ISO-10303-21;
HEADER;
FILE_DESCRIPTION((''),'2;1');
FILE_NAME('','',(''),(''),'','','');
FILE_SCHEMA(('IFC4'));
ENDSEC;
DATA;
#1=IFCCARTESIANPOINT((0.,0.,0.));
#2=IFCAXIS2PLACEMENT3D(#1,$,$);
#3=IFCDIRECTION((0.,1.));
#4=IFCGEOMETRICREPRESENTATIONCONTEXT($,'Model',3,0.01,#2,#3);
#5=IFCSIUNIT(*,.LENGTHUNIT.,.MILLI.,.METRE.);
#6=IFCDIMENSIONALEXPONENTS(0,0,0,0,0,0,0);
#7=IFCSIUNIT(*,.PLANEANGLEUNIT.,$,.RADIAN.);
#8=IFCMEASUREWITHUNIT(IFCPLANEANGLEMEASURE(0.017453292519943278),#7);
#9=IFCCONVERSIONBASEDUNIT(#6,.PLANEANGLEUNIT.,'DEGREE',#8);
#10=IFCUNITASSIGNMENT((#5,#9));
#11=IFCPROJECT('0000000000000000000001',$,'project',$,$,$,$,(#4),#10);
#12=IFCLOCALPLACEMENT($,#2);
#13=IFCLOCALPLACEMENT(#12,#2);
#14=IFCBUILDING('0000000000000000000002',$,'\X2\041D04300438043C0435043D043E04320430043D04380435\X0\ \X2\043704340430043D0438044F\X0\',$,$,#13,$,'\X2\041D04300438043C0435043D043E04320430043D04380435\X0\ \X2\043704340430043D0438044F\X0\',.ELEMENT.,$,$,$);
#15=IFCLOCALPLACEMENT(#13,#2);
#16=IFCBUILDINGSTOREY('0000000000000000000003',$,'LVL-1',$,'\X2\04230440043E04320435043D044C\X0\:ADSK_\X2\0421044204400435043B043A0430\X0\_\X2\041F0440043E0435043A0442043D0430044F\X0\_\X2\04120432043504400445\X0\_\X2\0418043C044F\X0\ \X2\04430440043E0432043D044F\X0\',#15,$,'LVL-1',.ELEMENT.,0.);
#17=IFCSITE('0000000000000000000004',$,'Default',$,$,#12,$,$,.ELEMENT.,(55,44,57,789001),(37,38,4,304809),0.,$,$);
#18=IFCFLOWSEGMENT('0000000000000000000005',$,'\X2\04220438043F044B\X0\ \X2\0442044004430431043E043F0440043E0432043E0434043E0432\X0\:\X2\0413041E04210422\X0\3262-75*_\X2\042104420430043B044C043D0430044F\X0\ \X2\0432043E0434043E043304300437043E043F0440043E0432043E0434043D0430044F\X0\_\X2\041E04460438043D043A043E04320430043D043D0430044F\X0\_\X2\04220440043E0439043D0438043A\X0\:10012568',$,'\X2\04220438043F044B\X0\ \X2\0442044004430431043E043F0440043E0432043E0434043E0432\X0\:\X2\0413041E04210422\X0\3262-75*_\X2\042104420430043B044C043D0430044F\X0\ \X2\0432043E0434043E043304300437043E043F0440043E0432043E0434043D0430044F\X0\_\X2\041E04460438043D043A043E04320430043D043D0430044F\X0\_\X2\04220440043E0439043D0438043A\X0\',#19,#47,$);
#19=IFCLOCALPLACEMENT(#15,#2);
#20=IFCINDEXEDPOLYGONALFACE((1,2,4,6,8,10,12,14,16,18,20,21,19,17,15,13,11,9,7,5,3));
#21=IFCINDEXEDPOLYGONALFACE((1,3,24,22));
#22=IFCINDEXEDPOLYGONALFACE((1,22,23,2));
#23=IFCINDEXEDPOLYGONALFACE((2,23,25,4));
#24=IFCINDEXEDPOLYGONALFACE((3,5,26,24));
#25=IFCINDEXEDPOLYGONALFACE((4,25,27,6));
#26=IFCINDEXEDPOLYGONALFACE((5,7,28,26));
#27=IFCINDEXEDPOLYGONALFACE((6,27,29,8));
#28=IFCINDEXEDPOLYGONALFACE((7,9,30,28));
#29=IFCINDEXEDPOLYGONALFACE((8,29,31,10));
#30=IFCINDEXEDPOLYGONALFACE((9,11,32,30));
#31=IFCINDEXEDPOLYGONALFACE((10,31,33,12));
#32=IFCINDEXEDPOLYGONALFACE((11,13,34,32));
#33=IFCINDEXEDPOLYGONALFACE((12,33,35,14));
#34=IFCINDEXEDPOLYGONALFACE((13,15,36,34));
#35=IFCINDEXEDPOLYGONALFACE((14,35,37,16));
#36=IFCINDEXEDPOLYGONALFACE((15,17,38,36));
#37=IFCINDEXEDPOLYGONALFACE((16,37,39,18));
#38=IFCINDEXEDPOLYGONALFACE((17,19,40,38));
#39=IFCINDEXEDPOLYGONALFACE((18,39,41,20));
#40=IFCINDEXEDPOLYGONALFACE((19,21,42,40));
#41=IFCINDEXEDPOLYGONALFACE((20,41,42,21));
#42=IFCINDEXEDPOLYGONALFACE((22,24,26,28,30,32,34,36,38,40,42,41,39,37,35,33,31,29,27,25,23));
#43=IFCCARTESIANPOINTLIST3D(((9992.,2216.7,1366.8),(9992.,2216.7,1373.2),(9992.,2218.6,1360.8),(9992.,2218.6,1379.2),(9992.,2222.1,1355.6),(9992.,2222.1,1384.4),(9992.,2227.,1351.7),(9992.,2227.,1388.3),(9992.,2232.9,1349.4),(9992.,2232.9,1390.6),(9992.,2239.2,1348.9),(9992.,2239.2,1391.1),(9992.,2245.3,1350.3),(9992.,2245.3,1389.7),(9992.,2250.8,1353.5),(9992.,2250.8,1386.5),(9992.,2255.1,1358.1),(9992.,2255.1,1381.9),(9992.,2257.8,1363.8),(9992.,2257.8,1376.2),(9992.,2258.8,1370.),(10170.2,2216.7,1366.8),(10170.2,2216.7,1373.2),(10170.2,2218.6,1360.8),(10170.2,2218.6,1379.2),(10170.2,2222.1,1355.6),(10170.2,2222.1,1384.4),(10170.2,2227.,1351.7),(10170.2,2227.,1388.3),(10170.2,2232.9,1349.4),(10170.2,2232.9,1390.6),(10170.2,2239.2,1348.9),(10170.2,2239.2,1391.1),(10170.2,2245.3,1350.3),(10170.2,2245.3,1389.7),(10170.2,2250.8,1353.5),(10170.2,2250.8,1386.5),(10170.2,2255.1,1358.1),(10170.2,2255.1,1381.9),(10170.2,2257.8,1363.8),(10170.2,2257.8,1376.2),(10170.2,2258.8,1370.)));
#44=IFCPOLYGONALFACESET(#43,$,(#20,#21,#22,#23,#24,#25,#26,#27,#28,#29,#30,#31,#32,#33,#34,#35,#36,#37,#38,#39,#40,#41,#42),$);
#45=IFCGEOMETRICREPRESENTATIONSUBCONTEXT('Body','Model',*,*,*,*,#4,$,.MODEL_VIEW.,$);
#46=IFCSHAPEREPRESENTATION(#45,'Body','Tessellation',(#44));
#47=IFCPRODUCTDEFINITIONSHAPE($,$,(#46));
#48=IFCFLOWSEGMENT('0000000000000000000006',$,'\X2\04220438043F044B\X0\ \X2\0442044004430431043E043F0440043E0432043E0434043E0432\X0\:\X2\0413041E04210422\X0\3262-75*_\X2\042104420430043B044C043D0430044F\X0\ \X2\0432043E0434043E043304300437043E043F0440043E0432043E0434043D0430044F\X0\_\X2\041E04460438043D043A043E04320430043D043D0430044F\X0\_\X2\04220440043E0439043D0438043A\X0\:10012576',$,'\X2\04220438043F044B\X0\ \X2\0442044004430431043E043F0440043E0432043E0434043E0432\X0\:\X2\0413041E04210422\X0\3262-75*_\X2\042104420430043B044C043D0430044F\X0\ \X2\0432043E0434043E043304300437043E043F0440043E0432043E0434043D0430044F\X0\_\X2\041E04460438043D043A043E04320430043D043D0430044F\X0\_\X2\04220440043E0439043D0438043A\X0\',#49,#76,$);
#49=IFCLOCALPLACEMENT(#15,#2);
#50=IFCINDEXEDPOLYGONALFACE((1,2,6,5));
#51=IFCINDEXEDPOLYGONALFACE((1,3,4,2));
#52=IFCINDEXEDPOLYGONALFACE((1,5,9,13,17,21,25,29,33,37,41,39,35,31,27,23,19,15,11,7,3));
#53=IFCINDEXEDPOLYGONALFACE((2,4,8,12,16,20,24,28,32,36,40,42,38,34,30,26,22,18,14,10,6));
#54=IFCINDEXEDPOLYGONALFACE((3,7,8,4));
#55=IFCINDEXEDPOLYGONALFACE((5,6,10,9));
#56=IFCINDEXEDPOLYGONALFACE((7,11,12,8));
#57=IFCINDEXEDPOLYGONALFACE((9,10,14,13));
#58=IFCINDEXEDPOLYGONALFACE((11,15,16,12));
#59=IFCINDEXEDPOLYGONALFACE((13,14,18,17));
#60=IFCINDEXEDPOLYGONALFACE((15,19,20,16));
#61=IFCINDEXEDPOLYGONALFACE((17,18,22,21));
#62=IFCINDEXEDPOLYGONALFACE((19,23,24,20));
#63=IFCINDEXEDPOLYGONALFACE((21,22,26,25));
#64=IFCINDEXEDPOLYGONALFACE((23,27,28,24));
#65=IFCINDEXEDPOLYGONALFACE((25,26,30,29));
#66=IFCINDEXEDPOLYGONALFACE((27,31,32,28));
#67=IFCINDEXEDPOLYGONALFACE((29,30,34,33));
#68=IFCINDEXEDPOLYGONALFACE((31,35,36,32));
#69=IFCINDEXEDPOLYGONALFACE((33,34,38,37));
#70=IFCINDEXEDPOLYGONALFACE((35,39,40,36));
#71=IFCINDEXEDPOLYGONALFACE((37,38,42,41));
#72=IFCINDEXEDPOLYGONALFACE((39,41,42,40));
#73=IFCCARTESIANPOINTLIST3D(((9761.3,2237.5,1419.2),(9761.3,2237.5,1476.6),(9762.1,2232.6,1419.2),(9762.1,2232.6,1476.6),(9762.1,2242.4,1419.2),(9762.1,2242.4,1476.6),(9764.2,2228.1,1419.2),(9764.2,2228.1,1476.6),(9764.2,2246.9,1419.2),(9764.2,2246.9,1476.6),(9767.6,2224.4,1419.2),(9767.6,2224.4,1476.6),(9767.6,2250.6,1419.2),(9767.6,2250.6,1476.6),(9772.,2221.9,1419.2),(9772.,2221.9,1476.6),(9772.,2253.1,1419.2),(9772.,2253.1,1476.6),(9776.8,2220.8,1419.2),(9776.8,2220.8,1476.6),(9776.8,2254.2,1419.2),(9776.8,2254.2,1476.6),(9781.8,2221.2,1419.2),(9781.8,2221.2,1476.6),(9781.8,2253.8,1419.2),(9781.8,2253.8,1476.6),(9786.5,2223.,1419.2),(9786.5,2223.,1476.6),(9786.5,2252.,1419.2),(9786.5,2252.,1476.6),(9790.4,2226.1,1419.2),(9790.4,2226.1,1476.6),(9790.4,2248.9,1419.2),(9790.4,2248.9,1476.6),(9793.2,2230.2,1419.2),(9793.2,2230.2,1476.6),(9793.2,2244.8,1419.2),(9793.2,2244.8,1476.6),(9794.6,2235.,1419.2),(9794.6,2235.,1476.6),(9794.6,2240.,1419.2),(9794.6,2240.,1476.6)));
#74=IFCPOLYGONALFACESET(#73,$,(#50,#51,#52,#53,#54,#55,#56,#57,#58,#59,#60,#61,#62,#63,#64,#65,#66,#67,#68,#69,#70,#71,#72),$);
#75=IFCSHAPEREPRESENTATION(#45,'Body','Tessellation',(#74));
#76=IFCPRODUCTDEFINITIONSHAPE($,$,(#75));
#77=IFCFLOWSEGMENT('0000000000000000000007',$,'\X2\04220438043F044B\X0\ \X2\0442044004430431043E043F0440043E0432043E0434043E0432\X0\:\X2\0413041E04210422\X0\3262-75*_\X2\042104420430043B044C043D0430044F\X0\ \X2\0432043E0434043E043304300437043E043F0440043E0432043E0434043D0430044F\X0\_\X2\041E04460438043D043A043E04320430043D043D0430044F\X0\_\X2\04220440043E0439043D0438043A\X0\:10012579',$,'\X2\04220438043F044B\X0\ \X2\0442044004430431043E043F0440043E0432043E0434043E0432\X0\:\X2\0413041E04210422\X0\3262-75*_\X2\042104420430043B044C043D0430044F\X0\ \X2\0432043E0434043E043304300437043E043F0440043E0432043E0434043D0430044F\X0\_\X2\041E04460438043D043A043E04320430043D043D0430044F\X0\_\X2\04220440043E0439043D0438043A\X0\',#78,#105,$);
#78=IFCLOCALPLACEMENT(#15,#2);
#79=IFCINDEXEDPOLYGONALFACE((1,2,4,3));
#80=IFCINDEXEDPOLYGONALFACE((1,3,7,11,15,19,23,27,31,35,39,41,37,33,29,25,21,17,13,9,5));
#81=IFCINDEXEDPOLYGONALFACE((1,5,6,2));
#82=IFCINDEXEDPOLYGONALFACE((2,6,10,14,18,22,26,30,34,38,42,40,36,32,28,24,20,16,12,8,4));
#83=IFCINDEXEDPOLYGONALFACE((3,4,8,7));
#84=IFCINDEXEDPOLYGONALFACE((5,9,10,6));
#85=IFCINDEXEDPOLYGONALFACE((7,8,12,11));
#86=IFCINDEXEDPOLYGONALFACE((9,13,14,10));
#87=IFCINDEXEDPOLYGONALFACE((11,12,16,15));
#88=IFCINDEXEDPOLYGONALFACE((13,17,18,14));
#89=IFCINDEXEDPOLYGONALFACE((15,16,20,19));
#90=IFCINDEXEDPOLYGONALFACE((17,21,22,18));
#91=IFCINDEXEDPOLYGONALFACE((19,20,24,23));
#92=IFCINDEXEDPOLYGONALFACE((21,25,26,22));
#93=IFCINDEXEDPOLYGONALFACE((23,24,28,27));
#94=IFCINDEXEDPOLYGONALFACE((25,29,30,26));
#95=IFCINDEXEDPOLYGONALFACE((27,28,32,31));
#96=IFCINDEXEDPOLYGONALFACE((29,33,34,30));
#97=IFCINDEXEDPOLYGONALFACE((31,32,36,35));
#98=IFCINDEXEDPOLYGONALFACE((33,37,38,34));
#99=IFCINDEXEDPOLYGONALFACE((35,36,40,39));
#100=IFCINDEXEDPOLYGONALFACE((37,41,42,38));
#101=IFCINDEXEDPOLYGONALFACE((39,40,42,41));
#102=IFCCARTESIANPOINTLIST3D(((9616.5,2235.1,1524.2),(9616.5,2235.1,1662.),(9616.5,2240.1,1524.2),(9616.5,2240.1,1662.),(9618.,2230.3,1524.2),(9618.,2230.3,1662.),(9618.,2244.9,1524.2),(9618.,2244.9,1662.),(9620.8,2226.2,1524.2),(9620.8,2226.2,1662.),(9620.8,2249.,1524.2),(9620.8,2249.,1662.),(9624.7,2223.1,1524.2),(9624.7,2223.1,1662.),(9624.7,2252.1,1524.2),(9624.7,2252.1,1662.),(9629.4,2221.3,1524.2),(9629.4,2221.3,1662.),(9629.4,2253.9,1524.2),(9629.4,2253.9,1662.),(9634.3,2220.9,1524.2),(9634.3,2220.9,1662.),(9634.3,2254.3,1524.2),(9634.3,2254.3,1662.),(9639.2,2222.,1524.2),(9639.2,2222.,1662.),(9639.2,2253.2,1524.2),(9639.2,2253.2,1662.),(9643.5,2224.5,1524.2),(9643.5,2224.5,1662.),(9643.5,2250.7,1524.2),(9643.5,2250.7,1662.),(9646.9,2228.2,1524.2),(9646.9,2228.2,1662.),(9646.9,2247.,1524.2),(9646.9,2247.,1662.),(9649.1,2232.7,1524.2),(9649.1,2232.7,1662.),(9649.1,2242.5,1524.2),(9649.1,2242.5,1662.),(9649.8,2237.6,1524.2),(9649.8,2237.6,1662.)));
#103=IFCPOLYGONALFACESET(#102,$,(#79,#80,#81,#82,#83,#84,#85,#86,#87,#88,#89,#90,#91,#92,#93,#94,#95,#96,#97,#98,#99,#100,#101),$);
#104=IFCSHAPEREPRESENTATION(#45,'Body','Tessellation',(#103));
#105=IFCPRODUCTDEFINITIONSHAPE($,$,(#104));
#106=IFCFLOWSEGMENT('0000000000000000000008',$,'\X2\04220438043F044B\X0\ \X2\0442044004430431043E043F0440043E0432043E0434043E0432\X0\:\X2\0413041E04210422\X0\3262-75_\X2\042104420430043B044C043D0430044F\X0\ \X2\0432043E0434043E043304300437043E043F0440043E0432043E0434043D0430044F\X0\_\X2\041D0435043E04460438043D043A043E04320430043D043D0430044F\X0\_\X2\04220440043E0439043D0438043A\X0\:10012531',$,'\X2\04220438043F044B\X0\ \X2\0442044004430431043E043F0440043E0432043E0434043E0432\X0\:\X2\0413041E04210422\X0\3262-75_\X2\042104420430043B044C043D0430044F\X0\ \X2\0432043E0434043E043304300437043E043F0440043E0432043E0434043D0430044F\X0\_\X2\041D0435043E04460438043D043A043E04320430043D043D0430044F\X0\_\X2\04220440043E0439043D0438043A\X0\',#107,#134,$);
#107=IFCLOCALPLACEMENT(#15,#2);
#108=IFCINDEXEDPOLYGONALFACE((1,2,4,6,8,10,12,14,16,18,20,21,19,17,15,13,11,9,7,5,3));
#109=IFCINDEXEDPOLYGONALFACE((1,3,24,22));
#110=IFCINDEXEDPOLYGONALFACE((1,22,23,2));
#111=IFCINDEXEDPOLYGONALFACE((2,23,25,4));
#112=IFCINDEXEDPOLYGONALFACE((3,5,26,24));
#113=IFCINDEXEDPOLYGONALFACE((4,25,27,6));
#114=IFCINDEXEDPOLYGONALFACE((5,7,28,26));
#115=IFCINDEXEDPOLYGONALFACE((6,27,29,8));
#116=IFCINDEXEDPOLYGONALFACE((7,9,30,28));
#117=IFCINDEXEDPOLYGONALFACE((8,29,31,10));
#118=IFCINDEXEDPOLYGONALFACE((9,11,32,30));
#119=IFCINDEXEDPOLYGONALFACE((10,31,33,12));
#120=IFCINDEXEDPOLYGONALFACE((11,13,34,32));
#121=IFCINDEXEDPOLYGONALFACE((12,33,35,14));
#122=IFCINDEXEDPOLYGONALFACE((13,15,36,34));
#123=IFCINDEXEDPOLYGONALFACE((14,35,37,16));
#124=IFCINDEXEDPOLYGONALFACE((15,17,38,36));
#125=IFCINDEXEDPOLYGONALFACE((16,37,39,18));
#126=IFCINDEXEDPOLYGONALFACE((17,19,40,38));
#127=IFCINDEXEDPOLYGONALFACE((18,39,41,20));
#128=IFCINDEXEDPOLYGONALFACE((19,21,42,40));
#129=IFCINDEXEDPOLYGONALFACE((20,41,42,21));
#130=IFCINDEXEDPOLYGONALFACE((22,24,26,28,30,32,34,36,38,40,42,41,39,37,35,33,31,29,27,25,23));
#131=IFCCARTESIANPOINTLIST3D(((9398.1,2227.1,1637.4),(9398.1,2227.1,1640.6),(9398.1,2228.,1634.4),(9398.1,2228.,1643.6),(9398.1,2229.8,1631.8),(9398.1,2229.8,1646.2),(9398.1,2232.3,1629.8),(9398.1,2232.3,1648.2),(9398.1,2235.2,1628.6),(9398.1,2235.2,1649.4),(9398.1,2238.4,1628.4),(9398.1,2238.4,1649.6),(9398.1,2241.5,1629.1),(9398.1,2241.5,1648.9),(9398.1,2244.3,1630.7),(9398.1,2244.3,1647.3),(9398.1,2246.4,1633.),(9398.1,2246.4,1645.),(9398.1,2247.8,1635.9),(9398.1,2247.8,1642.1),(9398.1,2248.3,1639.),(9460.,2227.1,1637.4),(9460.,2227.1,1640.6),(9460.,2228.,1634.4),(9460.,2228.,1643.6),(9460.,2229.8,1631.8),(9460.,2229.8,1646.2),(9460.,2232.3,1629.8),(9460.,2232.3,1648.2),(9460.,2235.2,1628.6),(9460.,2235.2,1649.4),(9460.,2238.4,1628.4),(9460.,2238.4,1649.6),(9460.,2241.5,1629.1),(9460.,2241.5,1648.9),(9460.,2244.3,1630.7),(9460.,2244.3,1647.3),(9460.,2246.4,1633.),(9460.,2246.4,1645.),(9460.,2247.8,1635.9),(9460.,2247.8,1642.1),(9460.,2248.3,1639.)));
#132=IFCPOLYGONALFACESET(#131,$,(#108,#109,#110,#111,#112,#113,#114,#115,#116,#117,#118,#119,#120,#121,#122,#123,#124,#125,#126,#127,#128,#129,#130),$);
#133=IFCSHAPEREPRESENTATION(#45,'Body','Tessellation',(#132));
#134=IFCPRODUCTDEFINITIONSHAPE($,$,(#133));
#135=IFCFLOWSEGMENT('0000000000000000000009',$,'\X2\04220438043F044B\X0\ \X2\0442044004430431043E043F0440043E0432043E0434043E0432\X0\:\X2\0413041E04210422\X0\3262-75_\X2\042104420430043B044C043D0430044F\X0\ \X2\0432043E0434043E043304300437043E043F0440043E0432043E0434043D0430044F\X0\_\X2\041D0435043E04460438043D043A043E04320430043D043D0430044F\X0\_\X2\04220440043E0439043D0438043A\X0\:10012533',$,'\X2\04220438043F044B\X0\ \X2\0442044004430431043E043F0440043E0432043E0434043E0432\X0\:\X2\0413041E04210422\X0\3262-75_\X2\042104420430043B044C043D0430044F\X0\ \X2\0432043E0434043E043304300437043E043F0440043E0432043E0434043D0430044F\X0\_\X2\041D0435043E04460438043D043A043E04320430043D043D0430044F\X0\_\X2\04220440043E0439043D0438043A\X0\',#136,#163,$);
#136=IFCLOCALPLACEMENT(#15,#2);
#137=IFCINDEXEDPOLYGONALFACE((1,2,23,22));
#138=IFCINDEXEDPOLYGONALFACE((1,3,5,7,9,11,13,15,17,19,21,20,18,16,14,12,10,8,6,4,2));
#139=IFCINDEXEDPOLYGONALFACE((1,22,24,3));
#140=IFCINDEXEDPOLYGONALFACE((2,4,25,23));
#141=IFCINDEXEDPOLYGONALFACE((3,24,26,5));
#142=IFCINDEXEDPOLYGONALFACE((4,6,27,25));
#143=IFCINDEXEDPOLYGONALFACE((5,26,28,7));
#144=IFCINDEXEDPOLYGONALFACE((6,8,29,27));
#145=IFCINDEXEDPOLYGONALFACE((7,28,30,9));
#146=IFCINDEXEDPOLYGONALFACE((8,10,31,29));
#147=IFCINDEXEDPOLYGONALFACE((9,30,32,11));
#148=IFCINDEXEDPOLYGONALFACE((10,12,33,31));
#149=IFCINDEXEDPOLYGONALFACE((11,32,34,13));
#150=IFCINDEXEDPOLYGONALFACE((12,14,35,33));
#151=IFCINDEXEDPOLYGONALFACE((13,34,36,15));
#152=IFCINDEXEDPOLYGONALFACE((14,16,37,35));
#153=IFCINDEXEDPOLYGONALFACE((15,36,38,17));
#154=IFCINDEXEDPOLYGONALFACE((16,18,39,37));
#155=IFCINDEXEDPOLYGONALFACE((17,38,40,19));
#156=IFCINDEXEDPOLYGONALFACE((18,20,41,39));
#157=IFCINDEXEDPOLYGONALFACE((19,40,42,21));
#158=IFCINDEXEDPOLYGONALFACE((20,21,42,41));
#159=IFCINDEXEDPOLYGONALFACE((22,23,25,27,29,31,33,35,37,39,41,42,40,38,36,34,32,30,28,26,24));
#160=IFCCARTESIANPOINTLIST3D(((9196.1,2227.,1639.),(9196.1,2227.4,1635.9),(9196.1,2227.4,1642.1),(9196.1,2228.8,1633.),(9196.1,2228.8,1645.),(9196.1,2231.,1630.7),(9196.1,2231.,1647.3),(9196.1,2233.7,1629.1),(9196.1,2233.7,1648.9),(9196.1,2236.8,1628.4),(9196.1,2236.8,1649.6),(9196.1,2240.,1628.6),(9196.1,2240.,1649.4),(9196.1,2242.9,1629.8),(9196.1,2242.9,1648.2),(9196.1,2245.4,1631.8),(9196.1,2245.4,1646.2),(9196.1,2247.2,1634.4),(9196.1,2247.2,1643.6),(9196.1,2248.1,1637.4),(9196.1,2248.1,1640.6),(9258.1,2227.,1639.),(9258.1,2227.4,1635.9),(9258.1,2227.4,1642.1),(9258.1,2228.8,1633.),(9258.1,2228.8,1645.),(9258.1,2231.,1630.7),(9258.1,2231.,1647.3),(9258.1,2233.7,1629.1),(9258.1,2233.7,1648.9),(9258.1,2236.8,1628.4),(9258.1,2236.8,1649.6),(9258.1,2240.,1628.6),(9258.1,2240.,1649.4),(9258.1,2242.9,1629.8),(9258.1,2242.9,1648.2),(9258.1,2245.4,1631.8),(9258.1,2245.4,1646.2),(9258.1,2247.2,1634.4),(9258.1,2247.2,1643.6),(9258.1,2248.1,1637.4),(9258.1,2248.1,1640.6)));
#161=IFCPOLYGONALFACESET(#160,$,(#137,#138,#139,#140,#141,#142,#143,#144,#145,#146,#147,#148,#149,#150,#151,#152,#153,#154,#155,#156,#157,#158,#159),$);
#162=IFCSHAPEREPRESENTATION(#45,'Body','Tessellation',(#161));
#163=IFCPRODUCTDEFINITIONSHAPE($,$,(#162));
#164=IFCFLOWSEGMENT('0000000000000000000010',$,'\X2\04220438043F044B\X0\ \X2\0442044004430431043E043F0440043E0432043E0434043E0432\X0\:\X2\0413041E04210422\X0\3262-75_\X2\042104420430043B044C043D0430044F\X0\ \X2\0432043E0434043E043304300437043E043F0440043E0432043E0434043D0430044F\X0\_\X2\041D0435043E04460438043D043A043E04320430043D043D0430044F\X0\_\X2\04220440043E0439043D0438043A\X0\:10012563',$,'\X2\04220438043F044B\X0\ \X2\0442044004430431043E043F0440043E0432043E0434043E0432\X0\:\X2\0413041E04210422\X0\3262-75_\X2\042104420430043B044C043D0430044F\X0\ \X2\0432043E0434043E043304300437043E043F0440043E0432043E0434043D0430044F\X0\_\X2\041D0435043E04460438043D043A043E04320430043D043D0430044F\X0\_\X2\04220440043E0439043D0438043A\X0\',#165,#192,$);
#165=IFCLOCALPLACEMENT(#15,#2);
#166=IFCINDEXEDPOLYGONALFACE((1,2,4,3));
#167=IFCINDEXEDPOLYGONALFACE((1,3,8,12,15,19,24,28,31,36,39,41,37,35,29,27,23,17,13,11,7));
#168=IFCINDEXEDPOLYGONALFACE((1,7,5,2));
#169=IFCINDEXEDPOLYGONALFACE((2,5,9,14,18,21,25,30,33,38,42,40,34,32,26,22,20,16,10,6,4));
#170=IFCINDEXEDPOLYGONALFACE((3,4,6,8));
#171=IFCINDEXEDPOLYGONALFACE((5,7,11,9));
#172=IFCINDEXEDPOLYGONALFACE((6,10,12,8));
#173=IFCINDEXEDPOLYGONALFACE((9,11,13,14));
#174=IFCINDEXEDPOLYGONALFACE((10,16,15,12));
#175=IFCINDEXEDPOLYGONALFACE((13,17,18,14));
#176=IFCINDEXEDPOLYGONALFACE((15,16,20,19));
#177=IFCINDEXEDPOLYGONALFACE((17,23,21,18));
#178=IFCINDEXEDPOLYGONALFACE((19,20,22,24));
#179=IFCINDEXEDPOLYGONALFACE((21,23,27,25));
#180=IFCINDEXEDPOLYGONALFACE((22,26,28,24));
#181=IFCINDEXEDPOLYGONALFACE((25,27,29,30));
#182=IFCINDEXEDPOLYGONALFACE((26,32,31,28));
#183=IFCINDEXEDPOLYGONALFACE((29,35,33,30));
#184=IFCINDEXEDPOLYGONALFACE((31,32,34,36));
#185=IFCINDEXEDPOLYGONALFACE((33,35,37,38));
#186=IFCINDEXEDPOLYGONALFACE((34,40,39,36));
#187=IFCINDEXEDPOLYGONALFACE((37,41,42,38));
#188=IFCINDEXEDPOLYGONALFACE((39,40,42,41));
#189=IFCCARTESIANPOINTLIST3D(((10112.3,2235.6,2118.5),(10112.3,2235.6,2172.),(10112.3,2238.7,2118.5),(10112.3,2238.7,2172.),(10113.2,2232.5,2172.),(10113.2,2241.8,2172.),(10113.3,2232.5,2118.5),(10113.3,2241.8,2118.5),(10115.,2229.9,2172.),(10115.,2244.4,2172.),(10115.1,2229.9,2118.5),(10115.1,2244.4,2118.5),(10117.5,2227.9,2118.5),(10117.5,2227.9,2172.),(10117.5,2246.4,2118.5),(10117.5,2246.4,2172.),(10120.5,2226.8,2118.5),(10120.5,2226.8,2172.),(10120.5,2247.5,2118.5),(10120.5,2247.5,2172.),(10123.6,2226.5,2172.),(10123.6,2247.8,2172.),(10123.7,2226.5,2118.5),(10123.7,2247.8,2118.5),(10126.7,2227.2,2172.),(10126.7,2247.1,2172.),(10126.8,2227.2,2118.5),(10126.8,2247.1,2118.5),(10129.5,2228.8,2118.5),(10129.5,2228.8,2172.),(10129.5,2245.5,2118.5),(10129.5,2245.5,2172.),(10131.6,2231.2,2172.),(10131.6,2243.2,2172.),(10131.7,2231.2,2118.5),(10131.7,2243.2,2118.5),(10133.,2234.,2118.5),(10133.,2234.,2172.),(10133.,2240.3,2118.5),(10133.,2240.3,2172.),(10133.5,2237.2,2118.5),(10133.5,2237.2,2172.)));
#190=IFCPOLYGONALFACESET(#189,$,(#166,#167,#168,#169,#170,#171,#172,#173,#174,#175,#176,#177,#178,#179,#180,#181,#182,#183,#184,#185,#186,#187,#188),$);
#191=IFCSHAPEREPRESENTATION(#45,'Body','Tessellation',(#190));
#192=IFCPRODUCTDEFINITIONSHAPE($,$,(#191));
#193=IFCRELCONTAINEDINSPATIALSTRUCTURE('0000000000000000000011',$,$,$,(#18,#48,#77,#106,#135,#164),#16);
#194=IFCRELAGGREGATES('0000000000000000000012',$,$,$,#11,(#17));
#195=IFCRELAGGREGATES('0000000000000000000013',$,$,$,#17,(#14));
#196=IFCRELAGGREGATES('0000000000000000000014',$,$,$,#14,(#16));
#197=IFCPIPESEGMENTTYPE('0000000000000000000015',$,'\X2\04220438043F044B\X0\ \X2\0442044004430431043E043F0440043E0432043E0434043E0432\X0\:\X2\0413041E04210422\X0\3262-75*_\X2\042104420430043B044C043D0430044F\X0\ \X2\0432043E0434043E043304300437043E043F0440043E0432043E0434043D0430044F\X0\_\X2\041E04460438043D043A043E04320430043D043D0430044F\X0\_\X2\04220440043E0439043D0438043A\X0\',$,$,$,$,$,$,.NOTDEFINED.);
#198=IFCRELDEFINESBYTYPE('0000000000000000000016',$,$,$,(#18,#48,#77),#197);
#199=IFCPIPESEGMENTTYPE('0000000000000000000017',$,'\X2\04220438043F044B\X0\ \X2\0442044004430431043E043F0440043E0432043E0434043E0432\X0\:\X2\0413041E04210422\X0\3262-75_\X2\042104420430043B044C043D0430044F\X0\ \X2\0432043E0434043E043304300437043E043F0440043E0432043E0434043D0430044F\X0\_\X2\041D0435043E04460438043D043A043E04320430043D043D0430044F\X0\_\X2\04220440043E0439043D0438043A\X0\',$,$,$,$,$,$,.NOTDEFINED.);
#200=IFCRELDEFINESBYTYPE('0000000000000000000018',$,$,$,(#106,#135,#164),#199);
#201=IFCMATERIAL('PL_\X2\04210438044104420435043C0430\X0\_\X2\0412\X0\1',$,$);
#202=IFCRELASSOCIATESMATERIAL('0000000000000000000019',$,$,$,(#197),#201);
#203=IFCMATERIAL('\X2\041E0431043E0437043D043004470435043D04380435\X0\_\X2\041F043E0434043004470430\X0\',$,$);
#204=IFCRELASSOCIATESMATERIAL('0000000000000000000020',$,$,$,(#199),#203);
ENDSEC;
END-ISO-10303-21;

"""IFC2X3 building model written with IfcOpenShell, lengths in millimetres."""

from ifc_helpers import new_model, entity, si_unit, converted_unit, direction, frame, frame_2d, origin, origin_2d_with_axis, place, context, subcontext, project, spatial, circle, extrude, material, type_object, element, save


model = new_model("IFC2X3")

# Units and contexts
model_context = context("Model", 3, precision=0.01, world=origin(), true_north=direction((0.0, 1.0)))
body_context = subcontext(model_context, "Body", "Model", "MODEL_VIEW")
ifc_project = project(units=[si_unit("LENGTHUNIT", "METRE", prefix="MILLI"), converted_unit("PLANEANGLEUNIT", "DEGREE", entity("IfcPlaneAngleMeasure", 0.017453292519943278), si_unit("PLANEANGLEUNIT", "RADIAN"), dimensions=[0, 0, 0, 0, 0, 0, 0])], contexts=[model_context])

# Site, building, storey
site_placement = place(None, origin())
site = spatial("IfcSite", under=ifc_project, at=site_placement, Name="Default", CompositionType="ELEMENT", RefLatitude=(55, 44, 57, 789001), RefLongitude=(37, 38, 4, 304809), RefElevation=0.0)
building_placement = place(site_placement, origin())
building = spatial("IfcBuilding", under=site, at=building_placement, Name="Наименование здания", LongName="Наименование здания", CompositionType="ELEMENT")
storey_placement = place(building_placement, origin())
storey = spatial("IfcBuildingStorey", under=building, at=storey_placement, Name="LVL-1", ObjectType="Уровень:ADSK_Стрелка_Проектная_Вверх_Имя уровня", LongName="LVL-1", CompositionType="ELEMENT", Elevation=0.0)

# Flow segments
ifc_material_1 = material(Name="PL_Система_В1")
pipe_segment_type_1 = type_object("IfcPipeSegmentType", Name="Типы трубопроводов:ГОСТ3262-75*_Стальная водогазопроводная_Оцинкованная_Тройник", PredefinedType="NOTDEFINED", material=ifc_material_1)
flow_segment_1_placement = place(storey_placement, origin())
element("IfcFlowSegment", 1, at=flow_segment_1_placement, inside=storey, type_object=pipe_segment_type_1, Name="Типы трубопроводов:ГОСТ3262-75*_Стальная водогазопроводная_Оцинкованная_Тройник:10012568", ObjectType="Типы трубопроводов:ГОСТ3262-75*_Стальная водогазопроводная_Оцинкованная_Тройник", context=body_context, shape_type="SweptSolid", body=[
    extrude(circle(Radius=21.1, at=origin_2d_with_axis()), frame((9992.0, 2237.6, 1370.0), z_axis=(1.0, 0.0, 0.0), x_axis=(0.0, 1.0, 0.0)), (0.0, 0.0, 1.0), 178.2),
])
flow_segment_2_placement = place(storey_placement, origin())
element("IfcFlowSegment", 2, at=flow_segment_2_placement, inside=storey, type_object=pipe_segment_type_1, Name="Типы трубопроводов:ГОСТ3262-75*_Стальная водогазопроводная_Оцинкованная_Тройник:10012576", ObjectType="Типы трубопроводов:ГОСТ3262-75*_Стальная водогазопроводная_Оцинкованная_Тройник", context=body_context, shape_type="SweptSolid", body=[
    extrude(circle(Radius=16.8, at=origin_2d_with_axis()), frame((9778.1, 2237.5, 1419.2), z_axis=(0.0, 0.0, 1.0), x_axis=(-1.0, 0.0, 0.0)), (0.0, 0.0, 1.0), 57.4),
])
flow_segment_3_placement = place(storey_placement, origin())
element("IfcFlowSegment", 3, at=flow_segment_3_placement, inside=storey, type_object=pipe_segment_type_1, Name="Типы трубопроводов:ГОСТ3262-75*_Стальная водогазопроводная_Оцинкованная_Тройник:10012579", ObjectType="Типы трубопроводов:ГОСТ3262-75*_Стальная водогазопроводная_Оцинкованная_Тройник", context=body_context, shape_type="SweptSolid", body=[
    extrude(circle(Radius=16.8, at=origin_2d_with_axis()), frame((9633.1, 2237.6, 1524.2)), (0.0, 0.0, 1.0), 137.8),
])
ifc_material_2 = material(Name="Обозначение_Подача")
pipe_segment_type_2 = type_object("IfcPipeSegmentType", Name="Типы трубопроводов:ГОСТ3262-75_Стальная водогазопроводная_Неоцинкованная_Тройник", PredefinedType="NOTDEFINED", material=ifc_material_2)
flow_segment_4_placement = place(storey_placement, origin())
element("IfcFlowSegment", 4, at=flow_segment_4_placement, inside=storey, type_object=pipe_segment_type_2, Name="Типы трубопроводов:ГОСТ3262-75_Стальная водогазопроводная_Неоцинкованная_Тройник:10012531", ObjectType="Типы трубопроводов:ГОСТ3262-75_Стальная водогазопроводная_Неоцинкованная_Тройник", context=body_context, shape_type="SweptSolid", body=[
    extrude(circle(Radius=10.7, at=frame_2d((0.0, 0.0), x_axis=(1.0, 0.0))), frame((9398.1, 2237.6, 1639.0), z_axis=(1.0, 0.0, 0.0), x_axis=(0.0, 1.0, 0.0)), (0.0, 0.0, 1.0), 62.0),
])
flow_segment_5_placement = place(storey_placement, origin())
element("IfcFlowSegment", 5, at=flow_segment_5_placement, inside=storey, type_object=pipe_segment_type_2, Name="Типы трубопроводов:ГОСТ3262-75_Стальная водогазопроводная_Неоцинкованная_Тройник:10012533", ObjectType="Типы трубопроводов:ГОСТ3262-75_Стальная водогазопроводная_Неоцинкованная_Тройник", context=body_context, shape_type="SweptSolid", body=[
    extrude(circle(Radius=10.7, at=frame_2d((0.0, 0.0), x_axis=(1.0, 0.0))), frame((9196.1, 2237.6, 1639.0), z_axis=(1.0, 0.0, 0.0), x_axis=(0.0, -1.0, 0.0)), (0.0, 0.0, 1.0), 62.0),
])
flow_segment_6_placement = place(storey_placement, origin())
element("IfcFlowSegment", 6, at=flow_segment_6_placement, inside=storey, type_object=pipe_segment_type_2, Name="Типы трубопроводов:ГОСТ3262-75_Стальная водогазопроводная_Неоцинкованная_Тройник:10012563", ObjectType="Типы трубопроводов:ГОСТ3262-75_Стальная водогазопроводная_Неоцинкованная_Тройник", context=body_context, shape_type="SweptSolid", body=[
    extrude(circle(Radius=10.7, at=origin_2d_with_axis()), frame((10122.9, 2237.2, 2118.5), z_axis=(-0.000466, 0.0, 1.0), x_axis=(1.0, 0.0, 0.000466)), (0.0, 0.0, 1.0), 53.5),
])

save(model, "model.ifc")
